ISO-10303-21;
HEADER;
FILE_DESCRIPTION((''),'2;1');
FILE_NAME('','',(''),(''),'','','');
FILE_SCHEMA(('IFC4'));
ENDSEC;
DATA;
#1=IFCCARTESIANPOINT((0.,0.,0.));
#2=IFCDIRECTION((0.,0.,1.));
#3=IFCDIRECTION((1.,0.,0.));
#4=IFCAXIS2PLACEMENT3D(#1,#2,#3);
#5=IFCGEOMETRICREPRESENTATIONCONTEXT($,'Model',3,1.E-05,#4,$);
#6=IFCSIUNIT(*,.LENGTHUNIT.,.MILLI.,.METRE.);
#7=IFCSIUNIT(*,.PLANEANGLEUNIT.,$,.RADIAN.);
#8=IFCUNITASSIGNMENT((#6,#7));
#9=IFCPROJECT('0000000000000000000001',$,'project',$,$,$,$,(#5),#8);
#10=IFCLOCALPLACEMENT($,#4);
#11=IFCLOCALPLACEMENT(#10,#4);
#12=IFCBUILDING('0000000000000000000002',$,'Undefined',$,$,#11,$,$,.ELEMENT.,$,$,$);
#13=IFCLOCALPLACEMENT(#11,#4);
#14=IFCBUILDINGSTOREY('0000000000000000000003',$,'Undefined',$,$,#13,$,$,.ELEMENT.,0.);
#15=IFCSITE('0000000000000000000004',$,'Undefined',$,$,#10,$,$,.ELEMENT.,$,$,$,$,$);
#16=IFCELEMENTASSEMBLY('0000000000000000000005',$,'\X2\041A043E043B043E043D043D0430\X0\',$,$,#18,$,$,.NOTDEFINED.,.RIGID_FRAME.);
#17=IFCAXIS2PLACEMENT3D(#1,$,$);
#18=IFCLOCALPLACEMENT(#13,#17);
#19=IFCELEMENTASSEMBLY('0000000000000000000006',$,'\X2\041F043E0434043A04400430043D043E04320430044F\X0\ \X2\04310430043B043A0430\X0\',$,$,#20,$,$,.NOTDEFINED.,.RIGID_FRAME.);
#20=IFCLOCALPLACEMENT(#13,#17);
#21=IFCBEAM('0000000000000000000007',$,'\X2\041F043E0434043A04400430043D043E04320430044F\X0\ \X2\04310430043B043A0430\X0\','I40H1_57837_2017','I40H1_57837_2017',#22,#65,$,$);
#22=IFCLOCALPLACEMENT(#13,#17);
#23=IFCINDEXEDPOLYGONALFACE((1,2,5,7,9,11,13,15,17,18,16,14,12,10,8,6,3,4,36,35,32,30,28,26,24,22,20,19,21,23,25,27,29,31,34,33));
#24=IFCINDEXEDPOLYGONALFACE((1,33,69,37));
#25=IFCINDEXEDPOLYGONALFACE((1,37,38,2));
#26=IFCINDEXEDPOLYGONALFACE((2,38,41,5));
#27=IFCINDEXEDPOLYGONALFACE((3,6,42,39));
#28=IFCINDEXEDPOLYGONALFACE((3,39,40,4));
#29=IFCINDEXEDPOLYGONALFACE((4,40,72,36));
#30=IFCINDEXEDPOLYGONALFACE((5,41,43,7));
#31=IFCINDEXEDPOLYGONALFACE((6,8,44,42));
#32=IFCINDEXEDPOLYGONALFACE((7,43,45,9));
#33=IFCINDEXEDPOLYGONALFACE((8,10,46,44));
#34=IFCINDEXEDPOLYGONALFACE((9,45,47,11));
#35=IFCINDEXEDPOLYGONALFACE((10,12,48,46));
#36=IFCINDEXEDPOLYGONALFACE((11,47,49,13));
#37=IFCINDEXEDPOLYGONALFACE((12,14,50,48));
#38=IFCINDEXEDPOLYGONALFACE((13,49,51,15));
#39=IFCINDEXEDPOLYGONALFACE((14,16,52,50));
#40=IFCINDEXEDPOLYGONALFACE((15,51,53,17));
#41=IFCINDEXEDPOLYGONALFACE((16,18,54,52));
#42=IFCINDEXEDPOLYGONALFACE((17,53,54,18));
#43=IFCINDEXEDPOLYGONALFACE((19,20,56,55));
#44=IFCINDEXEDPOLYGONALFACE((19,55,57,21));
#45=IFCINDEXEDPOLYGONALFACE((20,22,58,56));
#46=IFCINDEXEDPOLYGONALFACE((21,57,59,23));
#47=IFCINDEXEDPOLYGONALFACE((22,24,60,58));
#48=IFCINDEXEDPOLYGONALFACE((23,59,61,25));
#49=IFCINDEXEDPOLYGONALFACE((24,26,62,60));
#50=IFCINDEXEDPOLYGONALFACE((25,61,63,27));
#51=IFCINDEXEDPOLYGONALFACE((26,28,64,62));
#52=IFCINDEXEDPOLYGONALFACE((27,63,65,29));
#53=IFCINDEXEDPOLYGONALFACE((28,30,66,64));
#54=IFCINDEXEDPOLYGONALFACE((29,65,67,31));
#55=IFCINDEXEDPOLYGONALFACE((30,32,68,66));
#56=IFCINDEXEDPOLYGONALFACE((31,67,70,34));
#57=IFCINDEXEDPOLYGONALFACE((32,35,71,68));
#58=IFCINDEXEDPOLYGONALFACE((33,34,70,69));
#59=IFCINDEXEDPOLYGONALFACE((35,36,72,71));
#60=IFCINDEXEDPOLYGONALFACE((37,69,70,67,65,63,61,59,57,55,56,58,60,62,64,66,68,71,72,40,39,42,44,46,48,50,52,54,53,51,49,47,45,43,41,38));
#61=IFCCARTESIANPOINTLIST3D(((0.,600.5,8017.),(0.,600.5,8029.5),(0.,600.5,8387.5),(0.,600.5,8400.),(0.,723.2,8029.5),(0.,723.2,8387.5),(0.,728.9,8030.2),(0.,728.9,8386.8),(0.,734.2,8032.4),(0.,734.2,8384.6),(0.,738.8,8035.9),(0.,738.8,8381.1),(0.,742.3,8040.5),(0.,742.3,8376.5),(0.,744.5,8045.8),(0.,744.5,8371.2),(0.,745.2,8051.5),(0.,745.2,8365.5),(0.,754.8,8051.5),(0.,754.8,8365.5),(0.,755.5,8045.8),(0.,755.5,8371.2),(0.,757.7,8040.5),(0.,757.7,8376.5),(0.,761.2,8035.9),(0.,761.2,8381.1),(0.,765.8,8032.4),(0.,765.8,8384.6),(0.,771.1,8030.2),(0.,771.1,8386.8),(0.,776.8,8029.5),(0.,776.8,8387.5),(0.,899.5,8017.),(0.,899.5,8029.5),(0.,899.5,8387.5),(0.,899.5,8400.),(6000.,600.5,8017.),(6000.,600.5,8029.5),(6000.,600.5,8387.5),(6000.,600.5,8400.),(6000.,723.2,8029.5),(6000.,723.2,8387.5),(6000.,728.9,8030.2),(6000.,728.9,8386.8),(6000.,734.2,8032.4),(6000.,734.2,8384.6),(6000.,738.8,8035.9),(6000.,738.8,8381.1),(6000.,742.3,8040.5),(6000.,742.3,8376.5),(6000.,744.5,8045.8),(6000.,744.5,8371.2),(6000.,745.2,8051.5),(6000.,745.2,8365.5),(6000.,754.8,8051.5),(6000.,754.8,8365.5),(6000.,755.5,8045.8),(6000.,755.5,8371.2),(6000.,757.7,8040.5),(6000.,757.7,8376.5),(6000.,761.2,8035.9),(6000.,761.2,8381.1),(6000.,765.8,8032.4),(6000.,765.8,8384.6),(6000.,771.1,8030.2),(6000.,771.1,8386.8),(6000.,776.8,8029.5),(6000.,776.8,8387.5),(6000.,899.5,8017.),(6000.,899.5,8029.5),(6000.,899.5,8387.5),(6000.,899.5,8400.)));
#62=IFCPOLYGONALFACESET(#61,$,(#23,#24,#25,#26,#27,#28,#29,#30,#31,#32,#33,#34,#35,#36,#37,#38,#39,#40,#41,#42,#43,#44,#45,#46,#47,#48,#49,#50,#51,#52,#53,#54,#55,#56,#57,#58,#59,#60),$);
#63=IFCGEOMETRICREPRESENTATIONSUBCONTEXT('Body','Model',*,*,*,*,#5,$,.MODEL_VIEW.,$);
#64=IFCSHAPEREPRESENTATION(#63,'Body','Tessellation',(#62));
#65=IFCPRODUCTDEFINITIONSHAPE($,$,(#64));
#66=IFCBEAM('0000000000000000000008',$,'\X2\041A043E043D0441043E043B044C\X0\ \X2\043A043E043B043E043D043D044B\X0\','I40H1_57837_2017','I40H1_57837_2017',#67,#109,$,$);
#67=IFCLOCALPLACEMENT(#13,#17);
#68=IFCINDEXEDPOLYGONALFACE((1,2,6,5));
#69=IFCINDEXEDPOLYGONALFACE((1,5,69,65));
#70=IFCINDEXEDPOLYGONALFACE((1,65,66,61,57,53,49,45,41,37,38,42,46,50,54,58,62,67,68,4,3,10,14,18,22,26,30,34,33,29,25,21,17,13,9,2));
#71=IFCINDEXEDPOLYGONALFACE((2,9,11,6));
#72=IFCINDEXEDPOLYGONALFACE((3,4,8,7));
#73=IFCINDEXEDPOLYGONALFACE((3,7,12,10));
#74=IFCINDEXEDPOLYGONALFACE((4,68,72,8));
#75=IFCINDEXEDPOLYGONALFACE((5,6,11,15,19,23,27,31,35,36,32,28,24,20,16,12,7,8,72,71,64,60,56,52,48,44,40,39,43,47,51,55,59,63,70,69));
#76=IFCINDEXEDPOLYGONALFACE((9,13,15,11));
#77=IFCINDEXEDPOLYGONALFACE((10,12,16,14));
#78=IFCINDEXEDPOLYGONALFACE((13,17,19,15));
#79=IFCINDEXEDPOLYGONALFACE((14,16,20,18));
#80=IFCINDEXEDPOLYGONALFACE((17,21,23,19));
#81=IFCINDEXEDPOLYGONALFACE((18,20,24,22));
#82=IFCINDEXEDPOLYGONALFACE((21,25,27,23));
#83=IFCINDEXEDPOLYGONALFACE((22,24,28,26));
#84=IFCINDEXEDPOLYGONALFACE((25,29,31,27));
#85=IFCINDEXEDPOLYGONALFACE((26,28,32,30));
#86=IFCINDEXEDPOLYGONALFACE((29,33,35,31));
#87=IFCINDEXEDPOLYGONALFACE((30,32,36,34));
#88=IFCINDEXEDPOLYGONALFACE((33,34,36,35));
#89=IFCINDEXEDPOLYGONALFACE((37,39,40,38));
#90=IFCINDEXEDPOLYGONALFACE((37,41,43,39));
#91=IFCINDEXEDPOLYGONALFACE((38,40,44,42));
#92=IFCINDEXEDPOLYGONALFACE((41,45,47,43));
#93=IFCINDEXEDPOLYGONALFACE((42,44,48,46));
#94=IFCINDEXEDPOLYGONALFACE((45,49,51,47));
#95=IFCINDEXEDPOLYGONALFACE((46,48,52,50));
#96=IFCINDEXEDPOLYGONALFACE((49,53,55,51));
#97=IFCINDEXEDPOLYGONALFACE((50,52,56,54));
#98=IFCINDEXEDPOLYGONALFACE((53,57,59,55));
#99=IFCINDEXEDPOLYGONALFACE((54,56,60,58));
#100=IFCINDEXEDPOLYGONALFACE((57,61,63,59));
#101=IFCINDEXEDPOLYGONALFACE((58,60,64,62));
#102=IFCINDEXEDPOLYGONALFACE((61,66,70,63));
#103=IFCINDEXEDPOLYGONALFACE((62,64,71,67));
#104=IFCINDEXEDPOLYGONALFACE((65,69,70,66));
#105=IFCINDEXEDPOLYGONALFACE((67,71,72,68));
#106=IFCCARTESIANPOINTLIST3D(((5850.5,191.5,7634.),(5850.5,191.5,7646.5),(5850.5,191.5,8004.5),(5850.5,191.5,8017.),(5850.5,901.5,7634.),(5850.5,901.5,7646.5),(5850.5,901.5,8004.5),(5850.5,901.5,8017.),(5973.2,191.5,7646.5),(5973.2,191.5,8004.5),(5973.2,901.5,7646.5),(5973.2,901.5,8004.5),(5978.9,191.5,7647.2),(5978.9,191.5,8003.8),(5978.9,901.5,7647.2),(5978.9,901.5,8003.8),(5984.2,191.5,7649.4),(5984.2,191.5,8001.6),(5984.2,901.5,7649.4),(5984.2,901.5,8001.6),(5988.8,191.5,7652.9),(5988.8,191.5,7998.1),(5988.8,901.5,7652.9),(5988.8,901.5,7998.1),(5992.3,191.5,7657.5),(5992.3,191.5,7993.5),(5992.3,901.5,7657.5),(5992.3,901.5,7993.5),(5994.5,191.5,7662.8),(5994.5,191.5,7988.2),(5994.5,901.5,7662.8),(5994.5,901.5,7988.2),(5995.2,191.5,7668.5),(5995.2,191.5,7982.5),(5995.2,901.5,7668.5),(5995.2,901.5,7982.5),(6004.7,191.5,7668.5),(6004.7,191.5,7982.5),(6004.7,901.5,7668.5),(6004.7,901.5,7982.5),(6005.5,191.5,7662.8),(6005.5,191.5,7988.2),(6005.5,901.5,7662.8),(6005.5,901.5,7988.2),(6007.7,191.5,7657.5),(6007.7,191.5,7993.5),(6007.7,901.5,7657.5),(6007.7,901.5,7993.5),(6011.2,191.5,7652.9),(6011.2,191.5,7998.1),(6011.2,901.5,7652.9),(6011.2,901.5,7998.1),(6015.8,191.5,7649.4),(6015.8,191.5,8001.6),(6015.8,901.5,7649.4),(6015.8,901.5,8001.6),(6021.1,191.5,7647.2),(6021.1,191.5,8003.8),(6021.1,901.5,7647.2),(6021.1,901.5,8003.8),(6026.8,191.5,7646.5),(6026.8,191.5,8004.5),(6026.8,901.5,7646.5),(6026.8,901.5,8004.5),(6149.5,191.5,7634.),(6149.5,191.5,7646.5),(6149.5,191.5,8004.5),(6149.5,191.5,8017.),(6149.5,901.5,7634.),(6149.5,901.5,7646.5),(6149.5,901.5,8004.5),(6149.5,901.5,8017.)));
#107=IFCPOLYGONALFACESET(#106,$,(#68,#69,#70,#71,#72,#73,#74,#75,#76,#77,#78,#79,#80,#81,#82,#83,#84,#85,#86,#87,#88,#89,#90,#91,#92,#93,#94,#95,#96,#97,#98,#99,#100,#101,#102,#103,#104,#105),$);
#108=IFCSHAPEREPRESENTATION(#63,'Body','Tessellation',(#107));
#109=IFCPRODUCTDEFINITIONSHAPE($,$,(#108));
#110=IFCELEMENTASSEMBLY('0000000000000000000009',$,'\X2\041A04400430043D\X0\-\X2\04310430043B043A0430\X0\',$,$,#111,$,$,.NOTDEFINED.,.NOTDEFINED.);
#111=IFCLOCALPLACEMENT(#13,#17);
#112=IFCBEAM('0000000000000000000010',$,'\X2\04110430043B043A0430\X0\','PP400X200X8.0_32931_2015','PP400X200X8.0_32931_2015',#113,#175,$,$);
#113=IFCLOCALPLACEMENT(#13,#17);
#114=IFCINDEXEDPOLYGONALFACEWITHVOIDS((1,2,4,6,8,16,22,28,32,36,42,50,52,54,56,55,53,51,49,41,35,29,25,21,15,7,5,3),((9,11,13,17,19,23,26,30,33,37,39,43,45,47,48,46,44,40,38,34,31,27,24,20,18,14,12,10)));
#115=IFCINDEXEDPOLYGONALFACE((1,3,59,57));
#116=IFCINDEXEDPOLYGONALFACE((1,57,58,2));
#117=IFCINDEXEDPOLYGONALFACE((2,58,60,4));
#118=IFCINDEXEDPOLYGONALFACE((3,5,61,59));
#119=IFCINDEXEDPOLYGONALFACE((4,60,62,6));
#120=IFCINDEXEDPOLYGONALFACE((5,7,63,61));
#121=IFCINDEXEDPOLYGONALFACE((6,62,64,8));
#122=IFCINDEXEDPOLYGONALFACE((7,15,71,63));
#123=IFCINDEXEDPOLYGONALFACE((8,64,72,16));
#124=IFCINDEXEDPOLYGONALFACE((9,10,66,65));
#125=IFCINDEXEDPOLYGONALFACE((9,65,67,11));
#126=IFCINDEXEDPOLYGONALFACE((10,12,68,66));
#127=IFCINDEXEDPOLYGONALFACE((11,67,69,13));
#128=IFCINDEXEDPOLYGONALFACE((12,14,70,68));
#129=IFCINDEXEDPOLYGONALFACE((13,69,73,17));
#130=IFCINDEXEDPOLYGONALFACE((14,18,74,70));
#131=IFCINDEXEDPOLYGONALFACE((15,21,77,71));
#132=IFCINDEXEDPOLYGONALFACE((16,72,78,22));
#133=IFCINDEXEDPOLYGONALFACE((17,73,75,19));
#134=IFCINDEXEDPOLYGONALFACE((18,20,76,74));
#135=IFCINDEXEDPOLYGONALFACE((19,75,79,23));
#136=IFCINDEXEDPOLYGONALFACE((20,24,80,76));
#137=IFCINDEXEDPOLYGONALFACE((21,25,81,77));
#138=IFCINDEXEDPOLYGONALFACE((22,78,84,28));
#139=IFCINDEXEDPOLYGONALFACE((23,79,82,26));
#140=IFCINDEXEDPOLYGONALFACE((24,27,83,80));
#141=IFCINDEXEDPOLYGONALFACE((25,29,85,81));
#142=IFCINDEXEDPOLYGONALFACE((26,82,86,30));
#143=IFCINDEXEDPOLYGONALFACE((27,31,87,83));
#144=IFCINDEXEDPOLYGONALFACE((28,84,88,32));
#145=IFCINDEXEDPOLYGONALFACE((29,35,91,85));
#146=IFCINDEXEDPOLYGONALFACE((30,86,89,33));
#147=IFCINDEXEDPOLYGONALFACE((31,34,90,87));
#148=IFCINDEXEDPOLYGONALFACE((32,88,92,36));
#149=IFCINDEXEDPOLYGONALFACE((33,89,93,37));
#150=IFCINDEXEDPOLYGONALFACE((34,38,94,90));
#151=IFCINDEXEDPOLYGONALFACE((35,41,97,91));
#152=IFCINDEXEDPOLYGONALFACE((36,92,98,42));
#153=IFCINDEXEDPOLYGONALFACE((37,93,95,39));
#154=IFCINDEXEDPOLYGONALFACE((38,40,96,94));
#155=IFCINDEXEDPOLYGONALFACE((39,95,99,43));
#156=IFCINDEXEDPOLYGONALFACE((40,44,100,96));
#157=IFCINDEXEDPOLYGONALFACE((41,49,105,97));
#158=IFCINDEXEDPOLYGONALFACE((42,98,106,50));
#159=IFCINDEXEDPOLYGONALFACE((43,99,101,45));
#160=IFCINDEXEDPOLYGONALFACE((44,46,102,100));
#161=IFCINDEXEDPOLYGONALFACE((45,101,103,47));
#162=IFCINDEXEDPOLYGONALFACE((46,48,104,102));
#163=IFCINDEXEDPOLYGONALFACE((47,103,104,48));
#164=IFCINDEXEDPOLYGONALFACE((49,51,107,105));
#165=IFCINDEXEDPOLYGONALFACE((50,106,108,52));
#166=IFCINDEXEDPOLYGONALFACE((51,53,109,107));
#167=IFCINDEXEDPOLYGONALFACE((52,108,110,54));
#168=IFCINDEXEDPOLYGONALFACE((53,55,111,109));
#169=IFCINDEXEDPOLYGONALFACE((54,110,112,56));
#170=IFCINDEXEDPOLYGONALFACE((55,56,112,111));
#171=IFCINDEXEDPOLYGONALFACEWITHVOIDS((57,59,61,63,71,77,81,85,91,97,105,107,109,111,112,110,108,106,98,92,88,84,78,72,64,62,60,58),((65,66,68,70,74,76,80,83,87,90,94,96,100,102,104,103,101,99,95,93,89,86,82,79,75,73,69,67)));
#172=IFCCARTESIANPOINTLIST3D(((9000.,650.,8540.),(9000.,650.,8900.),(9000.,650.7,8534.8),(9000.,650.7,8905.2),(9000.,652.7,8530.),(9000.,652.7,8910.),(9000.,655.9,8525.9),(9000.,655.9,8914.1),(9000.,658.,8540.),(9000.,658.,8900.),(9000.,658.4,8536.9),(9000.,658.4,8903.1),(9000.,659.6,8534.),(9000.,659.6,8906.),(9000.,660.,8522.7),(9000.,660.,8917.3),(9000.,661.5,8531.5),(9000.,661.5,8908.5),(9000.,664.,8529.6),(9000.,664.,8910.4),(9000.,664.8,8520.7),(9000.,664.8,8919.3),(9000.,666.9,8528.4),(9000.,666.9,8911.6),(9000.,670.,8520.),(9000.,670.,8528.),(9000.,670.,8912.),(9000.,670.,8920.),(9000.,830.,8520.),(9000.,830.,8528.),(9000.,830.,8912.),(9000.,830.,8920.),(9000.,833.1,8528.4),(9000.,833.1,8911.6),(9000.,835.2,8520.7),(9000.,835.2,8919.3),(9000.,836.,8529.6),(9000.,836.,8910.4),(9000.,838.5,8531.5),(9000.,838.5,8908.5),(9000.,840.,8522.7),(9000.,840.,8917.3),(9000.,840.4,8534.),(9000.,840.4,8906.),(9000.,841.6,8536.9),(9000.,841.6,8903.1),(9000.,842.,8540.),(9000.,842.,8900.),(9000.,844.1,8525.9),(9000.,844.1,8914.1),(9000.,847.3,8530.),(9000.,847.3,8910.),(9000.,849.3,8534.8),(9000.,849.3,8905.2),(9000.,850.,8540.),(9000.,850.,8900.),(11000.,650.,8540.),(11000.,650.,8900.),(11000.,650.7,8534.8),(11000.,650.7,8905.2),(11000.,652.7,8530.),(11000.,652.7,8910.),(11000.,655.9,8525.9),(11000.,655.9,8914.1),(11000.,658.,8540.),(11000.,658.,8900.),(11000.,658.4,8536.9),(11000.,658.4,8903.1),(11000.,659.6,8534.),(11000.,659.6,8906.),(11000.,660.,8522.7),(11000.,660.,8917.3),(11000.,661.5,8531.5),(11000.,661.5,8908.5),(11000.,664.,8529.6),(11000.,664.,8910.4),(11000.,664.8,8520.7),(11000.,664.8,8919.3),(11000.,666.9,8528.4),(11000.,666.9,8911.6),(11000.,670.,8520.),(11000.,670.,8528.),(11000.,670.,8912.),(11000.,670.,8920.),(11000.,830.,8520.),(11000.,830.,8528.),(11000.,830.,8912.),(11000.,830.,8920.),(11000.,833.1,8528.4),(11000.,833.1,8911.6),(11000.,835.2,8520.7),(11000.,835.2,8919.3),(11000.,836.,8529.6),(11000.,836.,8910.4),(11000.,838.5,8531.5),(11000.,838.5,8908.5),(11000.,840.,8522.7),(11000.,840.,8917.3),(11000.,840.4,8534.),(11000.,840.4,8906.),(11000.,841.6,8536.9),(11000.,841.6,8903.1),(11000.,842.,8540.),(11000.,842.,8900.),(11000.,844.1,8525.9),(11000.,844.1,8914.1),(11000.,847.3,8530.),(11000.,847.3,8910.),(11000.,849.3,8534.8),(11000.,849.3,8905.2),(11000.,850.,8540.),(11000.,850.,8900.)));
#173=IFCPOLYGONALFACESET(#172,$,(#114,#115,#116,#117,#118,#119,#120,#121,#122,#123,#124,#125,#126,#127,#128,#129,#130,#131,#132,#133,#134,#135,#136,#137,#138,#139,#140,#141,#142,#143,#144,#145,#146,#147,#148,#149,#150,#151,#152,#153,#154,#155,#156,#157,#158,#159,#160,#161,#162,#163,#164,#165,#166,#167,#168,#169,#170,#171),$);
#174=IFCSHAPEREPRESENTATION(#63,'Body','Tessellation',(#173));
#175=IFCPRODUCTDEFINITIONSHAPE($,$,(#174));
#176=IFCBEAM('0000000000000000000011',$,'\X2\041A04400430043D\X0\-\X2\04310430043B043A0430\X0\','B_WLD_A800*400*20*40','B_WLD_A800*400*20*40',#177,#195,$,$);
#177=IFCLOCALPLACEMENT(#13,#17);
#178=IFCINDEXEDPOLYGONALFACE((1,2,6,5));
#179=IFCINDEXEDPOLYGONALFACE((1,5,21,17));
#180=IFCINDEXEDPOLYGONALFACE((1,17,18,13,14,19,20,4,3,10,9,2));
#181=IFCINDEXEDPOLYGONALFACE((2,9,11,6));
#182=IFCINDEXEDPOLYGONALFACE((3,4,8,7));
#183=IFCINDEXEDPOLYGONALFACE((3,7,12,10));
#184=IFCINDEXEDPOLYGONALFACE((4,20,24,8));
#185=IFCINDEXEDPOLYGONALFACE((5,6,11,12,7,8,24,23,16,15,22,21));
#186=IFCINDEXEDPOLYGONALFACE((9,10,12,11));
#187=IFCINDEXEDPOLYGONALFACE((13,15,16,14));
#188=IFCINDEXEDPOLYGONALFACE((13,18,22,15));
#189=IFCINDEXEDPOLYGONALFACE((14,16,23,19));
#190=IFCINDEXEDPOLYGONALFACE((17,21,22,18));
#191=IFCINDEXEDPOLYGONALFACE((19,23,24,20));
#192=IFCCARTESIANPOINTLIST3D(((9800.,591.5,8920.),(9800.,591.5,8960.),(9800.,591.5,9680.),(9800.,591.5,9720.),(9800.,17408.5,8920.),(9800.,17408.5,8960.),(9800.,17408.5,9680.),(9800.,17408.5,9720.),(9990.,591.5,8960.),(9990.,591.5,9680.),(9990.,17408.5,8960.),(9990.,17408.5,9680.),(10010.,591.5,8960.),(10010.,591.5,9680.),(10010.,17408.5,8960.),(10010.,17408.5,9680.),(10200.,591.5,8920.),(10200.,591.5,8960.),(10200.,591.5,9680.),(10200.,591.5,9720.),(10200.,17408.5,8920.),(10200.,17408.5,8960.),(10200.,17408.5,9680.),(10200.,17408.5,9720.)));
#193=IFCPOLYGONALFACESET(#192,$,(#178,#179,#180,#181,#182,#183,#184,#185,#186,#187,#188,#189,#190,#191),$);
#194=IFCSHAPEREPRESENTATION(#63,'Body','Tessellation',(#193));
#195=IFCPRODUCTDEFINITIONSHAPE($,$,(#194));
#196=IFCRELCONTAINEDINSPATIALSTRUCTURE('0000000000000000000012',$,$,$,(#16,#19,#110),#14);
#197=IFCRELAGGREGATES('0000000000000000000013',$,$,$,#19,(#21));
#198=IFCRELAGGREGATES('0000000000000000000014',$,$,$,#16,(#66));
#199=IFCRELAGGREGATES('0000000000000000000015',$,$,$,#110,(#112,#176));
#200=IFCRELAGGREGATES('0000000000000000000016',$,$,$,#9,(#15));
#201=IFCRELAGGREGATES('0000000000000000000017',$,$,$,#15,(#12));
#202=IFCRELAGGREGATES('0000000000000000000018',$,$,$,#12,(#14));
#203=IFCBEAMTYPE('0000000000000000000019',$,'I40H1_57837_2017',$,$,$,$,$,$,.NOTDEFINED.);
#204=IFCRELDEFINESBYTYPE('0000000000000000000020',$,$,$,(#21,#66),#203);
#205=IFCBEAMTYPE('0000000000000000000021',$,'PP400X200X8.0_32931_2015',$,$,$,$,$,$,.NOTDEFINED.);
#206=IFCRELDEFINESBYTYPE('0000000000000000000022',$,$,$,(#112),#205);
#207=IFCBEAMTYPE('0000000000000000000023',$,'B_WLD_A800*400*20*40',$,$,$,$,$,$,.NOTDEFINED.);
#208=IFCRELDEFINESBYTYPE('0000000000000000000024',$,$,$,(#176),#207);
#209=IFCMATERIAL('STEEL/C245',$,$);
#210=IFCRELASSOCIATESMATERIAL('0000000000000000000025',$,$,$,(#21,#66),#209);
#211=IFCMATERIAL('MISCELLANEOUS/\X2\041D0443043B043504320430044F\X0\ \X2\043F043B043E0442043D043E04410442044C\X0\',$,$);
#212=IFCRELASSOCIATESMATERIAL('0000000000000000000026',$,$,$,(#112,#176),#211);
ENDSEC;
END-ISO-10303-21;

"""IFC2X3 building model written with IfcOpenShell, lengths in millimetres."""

from ifc_helpers import new_model, si_unit, frame, origin_with_axes, origin_2d_with_axis, place, context, subcontext, project, spatial, polyline, hollow_rectangle, i_section, outline, extrude, material, type_object, element, aggregate, save


model = new_model("IFC2X3")

# Units and contexts
model_context = context("Model", 3, precision=1e-05, world=origin_with_axes())
body_context = subcontext(model_context, "Body", "Model", "MODEL_VIEW")
ifc_project = project(units=[si_unit("LENGTHUNIT", "METRE", prefix="MILLI"), si_unit("PLANEANGLEUNIT", "RADIAN")], contexts=[model_context])

# Site, building, storey
site_placement = place(None, origin_with_axes())
site = spatial("IfcSite", under=ifc_project, at=site_placement, Name="Undefined", CompositionType="ELEMENT")
building_placement = place(site_placement, origin_with_axes())
building = spatial("IfcBuilding", under=site, at=building_placement, Name="Undefined", CompositionType="ELEMENT")
storey_placement = place(building_placement, origin_with_axes())
storey = spatial("IfcBuildingStorey", under=building, at=storey_placement, Name="Undefined", CompositionType="ELEMENT", Elevation=0.0)

# Element assembly
ifc_material_1 = material(Name="STEEL/C245")
assembly_1_placement = place(storey_placement, origin_with_axes())
assembly_1 = element("IfcElementAssembly", 1, at=assembly_1_placement, inside=storey, Name="Колонна", AssemblyPlace="NOTDEFINED", PredefinedType="RIGID_FRAME")

# Shared definitions
beam_type_1 = type_object("IfcBeamType", Name="I40H1_57837_2017", PredefinedType="NOTDEFINED")

# Element assembly, beam
assembly_2_placement = place(storey_placement, origin_with_axes())
assembly_2 = element("IfcElementAssembly", 2, at=assembly_2_placement, inside=storey, Name="Подкрановая балка", AssemblyPlace="NOTDEFINED", PredefinedType="RIGID_FRAME")
beam_1_placement = place(assembly_2_placement, frame((6000.0, 750.0, 8208.5), z_axis=(0.0, 0.0, 1.0), x_axis=(-1.0, 0.0, 0.0)))
beam_1 = element("IfcBeam", 3, at=beam_1_placement, type_object=beam_type_1, material=ifc_material_1, Name="Подкрановая балка", Description="I40H1_57837_2017", ObjectType="I40H1_57837_2017", context=body_context, shape_type="SweptSolid", body=[
    extrude(i_section(OverallWidth=299.0, OverallDepth=383.0, WebThickness=9.5, FlangeThickness=12.5, FilletRadius=22.0, at=origin_2d_with_axis()), frame((6000.0, 0.0, 0.0), z_axis=(-1.0, 0.0, 0.0), x_axis=(0.0, -1.0, 0.0)), (0.0, 0.0, 1.0), 6000.0),
])
aggregate(assembly_2, [beam_1])

# Beam
beam_2_placement = place(assembly_1_placement, frame((6000.0, 901.5, 7825.5), z_axis=(0.0, 0.0, 1.0), x_axis=(0.0, -1.0, 0.0)))
beam_2 = element("IfcBeam", 4, at=beam_2_placement, type_object=beam_type_1, material=ifc_material_1, Name="Консоль колонны", Description="I40H1_57837_2017", ObjectType="I40H1_57837_2017", context=body_context, shape_type="SweptSolid", body=[
    extrude(i_section(OverallWidth=299.0, OverallDepth=383.0, WebThickness=9.5, FlangeThickness=12.5, FilletRadius=22.0, at=origin_2d_with_axis()), frame((710.0, 0.0, 0.0), z_axis=(-1.0, 0.0, 0.0), x_axis=(0.0, -1.0, 0.0)), (0.0, 0.0, 1.0), 710.0),
])
aggregate(assembly_1, [beam_2])

# Element assembly, beams
assembly_3_placement = place(storey_placement, origin_with_axes())
assembly_3 = element("IfcElementAssembly", 5, at=assembly_3_placement, inside=storey, Name="Кран-балка", AssemblyPlace="NOTDEFINED", PredefinedType="NOTDEFINED")
ifc_material_2 = material(Name="MISCELLANEOUS/Нулевая плотность")
beam_type_2 = type_object("IfcBeamType", Name="PP400X200X8.0_32931_2015", PredefinedType="NOTDEFINED")
beam_3_placement = place(assembly_3_placement, frame((9000.0, 750.0, 8720.0), z_axis=(0.0, 0.0, 1.0), x_axis=(1.0, 0.0, 0.0)))
beam_3 = element("IfcBeam", 6, at=beam_3_placement, type_object=beam_type_2, material=ifc_material_2, Name="Балка", Description="PP400X200X8.0_32931_2015", ObjectType="PP400X200X8.0_32931_2015", context=body_context, shape_type="SweptSolid", body=[
    extrude(hollow_rectangle(XDim=200.0, YDim=400.0, WallThickness=8.0, InnerFilletRadius=12.0, OuterFilletRadius=20.0, at=origin_2d_with_axis()), frame((2000.0, 0.0, 0.0), z_axis=(-1.0, 0.0, 0.0), x_axis=(0.0, -1.0, 0.0)), (0.0, 0.0, 1.0), 2000.0),
])
beam_type_3 = type_object("IfcBeamType", Name="B_WLD_A800*400*20*40", PredefinedType="NOTDEFINED")
beam_4_placement = place(assembly_3_placement, frame((10000.0, 591.5, 9320.0), z_axis=(0.0, 0.0, 1.0), x_axis=(0.0, 1.0, 0.0)))
beam_4 = element("IfcBeam", 7, at=beam_4_placement, type_object=beam_type_3, material=ifc_material_2, Name="Кран-балка", Description="B_WLD_A800*400*20*40", ObjectType="B_WLD_A800*400*20*40", context=body_context, shape_type="SweptSolid", body=[
    extrude(outline(polyline([(-200.0, 360.0), (-200.0, 400.0), (200.0, 400.0), (200.0, 360.0), (10.0, 360.0), (10.0, -360.0), (200.0, -360.0), (200.0, -400.0), (-200.0, -400.0), (-200.0, -360.0), (-10.0, -360.0), (-10.0, 360.0), (-200.0, 360.0)])), frame((16817.0, 0.0, 0.0), z_axis=(-1.0, 0.0, 0.0), x_axis=(0.0, -1.0, 0.0)), (0.0, 0.0, 1.0), 16817.0),
])
aggregate(assembly_3, [beam_3, beam_4])

save(model, "model.ifc")
